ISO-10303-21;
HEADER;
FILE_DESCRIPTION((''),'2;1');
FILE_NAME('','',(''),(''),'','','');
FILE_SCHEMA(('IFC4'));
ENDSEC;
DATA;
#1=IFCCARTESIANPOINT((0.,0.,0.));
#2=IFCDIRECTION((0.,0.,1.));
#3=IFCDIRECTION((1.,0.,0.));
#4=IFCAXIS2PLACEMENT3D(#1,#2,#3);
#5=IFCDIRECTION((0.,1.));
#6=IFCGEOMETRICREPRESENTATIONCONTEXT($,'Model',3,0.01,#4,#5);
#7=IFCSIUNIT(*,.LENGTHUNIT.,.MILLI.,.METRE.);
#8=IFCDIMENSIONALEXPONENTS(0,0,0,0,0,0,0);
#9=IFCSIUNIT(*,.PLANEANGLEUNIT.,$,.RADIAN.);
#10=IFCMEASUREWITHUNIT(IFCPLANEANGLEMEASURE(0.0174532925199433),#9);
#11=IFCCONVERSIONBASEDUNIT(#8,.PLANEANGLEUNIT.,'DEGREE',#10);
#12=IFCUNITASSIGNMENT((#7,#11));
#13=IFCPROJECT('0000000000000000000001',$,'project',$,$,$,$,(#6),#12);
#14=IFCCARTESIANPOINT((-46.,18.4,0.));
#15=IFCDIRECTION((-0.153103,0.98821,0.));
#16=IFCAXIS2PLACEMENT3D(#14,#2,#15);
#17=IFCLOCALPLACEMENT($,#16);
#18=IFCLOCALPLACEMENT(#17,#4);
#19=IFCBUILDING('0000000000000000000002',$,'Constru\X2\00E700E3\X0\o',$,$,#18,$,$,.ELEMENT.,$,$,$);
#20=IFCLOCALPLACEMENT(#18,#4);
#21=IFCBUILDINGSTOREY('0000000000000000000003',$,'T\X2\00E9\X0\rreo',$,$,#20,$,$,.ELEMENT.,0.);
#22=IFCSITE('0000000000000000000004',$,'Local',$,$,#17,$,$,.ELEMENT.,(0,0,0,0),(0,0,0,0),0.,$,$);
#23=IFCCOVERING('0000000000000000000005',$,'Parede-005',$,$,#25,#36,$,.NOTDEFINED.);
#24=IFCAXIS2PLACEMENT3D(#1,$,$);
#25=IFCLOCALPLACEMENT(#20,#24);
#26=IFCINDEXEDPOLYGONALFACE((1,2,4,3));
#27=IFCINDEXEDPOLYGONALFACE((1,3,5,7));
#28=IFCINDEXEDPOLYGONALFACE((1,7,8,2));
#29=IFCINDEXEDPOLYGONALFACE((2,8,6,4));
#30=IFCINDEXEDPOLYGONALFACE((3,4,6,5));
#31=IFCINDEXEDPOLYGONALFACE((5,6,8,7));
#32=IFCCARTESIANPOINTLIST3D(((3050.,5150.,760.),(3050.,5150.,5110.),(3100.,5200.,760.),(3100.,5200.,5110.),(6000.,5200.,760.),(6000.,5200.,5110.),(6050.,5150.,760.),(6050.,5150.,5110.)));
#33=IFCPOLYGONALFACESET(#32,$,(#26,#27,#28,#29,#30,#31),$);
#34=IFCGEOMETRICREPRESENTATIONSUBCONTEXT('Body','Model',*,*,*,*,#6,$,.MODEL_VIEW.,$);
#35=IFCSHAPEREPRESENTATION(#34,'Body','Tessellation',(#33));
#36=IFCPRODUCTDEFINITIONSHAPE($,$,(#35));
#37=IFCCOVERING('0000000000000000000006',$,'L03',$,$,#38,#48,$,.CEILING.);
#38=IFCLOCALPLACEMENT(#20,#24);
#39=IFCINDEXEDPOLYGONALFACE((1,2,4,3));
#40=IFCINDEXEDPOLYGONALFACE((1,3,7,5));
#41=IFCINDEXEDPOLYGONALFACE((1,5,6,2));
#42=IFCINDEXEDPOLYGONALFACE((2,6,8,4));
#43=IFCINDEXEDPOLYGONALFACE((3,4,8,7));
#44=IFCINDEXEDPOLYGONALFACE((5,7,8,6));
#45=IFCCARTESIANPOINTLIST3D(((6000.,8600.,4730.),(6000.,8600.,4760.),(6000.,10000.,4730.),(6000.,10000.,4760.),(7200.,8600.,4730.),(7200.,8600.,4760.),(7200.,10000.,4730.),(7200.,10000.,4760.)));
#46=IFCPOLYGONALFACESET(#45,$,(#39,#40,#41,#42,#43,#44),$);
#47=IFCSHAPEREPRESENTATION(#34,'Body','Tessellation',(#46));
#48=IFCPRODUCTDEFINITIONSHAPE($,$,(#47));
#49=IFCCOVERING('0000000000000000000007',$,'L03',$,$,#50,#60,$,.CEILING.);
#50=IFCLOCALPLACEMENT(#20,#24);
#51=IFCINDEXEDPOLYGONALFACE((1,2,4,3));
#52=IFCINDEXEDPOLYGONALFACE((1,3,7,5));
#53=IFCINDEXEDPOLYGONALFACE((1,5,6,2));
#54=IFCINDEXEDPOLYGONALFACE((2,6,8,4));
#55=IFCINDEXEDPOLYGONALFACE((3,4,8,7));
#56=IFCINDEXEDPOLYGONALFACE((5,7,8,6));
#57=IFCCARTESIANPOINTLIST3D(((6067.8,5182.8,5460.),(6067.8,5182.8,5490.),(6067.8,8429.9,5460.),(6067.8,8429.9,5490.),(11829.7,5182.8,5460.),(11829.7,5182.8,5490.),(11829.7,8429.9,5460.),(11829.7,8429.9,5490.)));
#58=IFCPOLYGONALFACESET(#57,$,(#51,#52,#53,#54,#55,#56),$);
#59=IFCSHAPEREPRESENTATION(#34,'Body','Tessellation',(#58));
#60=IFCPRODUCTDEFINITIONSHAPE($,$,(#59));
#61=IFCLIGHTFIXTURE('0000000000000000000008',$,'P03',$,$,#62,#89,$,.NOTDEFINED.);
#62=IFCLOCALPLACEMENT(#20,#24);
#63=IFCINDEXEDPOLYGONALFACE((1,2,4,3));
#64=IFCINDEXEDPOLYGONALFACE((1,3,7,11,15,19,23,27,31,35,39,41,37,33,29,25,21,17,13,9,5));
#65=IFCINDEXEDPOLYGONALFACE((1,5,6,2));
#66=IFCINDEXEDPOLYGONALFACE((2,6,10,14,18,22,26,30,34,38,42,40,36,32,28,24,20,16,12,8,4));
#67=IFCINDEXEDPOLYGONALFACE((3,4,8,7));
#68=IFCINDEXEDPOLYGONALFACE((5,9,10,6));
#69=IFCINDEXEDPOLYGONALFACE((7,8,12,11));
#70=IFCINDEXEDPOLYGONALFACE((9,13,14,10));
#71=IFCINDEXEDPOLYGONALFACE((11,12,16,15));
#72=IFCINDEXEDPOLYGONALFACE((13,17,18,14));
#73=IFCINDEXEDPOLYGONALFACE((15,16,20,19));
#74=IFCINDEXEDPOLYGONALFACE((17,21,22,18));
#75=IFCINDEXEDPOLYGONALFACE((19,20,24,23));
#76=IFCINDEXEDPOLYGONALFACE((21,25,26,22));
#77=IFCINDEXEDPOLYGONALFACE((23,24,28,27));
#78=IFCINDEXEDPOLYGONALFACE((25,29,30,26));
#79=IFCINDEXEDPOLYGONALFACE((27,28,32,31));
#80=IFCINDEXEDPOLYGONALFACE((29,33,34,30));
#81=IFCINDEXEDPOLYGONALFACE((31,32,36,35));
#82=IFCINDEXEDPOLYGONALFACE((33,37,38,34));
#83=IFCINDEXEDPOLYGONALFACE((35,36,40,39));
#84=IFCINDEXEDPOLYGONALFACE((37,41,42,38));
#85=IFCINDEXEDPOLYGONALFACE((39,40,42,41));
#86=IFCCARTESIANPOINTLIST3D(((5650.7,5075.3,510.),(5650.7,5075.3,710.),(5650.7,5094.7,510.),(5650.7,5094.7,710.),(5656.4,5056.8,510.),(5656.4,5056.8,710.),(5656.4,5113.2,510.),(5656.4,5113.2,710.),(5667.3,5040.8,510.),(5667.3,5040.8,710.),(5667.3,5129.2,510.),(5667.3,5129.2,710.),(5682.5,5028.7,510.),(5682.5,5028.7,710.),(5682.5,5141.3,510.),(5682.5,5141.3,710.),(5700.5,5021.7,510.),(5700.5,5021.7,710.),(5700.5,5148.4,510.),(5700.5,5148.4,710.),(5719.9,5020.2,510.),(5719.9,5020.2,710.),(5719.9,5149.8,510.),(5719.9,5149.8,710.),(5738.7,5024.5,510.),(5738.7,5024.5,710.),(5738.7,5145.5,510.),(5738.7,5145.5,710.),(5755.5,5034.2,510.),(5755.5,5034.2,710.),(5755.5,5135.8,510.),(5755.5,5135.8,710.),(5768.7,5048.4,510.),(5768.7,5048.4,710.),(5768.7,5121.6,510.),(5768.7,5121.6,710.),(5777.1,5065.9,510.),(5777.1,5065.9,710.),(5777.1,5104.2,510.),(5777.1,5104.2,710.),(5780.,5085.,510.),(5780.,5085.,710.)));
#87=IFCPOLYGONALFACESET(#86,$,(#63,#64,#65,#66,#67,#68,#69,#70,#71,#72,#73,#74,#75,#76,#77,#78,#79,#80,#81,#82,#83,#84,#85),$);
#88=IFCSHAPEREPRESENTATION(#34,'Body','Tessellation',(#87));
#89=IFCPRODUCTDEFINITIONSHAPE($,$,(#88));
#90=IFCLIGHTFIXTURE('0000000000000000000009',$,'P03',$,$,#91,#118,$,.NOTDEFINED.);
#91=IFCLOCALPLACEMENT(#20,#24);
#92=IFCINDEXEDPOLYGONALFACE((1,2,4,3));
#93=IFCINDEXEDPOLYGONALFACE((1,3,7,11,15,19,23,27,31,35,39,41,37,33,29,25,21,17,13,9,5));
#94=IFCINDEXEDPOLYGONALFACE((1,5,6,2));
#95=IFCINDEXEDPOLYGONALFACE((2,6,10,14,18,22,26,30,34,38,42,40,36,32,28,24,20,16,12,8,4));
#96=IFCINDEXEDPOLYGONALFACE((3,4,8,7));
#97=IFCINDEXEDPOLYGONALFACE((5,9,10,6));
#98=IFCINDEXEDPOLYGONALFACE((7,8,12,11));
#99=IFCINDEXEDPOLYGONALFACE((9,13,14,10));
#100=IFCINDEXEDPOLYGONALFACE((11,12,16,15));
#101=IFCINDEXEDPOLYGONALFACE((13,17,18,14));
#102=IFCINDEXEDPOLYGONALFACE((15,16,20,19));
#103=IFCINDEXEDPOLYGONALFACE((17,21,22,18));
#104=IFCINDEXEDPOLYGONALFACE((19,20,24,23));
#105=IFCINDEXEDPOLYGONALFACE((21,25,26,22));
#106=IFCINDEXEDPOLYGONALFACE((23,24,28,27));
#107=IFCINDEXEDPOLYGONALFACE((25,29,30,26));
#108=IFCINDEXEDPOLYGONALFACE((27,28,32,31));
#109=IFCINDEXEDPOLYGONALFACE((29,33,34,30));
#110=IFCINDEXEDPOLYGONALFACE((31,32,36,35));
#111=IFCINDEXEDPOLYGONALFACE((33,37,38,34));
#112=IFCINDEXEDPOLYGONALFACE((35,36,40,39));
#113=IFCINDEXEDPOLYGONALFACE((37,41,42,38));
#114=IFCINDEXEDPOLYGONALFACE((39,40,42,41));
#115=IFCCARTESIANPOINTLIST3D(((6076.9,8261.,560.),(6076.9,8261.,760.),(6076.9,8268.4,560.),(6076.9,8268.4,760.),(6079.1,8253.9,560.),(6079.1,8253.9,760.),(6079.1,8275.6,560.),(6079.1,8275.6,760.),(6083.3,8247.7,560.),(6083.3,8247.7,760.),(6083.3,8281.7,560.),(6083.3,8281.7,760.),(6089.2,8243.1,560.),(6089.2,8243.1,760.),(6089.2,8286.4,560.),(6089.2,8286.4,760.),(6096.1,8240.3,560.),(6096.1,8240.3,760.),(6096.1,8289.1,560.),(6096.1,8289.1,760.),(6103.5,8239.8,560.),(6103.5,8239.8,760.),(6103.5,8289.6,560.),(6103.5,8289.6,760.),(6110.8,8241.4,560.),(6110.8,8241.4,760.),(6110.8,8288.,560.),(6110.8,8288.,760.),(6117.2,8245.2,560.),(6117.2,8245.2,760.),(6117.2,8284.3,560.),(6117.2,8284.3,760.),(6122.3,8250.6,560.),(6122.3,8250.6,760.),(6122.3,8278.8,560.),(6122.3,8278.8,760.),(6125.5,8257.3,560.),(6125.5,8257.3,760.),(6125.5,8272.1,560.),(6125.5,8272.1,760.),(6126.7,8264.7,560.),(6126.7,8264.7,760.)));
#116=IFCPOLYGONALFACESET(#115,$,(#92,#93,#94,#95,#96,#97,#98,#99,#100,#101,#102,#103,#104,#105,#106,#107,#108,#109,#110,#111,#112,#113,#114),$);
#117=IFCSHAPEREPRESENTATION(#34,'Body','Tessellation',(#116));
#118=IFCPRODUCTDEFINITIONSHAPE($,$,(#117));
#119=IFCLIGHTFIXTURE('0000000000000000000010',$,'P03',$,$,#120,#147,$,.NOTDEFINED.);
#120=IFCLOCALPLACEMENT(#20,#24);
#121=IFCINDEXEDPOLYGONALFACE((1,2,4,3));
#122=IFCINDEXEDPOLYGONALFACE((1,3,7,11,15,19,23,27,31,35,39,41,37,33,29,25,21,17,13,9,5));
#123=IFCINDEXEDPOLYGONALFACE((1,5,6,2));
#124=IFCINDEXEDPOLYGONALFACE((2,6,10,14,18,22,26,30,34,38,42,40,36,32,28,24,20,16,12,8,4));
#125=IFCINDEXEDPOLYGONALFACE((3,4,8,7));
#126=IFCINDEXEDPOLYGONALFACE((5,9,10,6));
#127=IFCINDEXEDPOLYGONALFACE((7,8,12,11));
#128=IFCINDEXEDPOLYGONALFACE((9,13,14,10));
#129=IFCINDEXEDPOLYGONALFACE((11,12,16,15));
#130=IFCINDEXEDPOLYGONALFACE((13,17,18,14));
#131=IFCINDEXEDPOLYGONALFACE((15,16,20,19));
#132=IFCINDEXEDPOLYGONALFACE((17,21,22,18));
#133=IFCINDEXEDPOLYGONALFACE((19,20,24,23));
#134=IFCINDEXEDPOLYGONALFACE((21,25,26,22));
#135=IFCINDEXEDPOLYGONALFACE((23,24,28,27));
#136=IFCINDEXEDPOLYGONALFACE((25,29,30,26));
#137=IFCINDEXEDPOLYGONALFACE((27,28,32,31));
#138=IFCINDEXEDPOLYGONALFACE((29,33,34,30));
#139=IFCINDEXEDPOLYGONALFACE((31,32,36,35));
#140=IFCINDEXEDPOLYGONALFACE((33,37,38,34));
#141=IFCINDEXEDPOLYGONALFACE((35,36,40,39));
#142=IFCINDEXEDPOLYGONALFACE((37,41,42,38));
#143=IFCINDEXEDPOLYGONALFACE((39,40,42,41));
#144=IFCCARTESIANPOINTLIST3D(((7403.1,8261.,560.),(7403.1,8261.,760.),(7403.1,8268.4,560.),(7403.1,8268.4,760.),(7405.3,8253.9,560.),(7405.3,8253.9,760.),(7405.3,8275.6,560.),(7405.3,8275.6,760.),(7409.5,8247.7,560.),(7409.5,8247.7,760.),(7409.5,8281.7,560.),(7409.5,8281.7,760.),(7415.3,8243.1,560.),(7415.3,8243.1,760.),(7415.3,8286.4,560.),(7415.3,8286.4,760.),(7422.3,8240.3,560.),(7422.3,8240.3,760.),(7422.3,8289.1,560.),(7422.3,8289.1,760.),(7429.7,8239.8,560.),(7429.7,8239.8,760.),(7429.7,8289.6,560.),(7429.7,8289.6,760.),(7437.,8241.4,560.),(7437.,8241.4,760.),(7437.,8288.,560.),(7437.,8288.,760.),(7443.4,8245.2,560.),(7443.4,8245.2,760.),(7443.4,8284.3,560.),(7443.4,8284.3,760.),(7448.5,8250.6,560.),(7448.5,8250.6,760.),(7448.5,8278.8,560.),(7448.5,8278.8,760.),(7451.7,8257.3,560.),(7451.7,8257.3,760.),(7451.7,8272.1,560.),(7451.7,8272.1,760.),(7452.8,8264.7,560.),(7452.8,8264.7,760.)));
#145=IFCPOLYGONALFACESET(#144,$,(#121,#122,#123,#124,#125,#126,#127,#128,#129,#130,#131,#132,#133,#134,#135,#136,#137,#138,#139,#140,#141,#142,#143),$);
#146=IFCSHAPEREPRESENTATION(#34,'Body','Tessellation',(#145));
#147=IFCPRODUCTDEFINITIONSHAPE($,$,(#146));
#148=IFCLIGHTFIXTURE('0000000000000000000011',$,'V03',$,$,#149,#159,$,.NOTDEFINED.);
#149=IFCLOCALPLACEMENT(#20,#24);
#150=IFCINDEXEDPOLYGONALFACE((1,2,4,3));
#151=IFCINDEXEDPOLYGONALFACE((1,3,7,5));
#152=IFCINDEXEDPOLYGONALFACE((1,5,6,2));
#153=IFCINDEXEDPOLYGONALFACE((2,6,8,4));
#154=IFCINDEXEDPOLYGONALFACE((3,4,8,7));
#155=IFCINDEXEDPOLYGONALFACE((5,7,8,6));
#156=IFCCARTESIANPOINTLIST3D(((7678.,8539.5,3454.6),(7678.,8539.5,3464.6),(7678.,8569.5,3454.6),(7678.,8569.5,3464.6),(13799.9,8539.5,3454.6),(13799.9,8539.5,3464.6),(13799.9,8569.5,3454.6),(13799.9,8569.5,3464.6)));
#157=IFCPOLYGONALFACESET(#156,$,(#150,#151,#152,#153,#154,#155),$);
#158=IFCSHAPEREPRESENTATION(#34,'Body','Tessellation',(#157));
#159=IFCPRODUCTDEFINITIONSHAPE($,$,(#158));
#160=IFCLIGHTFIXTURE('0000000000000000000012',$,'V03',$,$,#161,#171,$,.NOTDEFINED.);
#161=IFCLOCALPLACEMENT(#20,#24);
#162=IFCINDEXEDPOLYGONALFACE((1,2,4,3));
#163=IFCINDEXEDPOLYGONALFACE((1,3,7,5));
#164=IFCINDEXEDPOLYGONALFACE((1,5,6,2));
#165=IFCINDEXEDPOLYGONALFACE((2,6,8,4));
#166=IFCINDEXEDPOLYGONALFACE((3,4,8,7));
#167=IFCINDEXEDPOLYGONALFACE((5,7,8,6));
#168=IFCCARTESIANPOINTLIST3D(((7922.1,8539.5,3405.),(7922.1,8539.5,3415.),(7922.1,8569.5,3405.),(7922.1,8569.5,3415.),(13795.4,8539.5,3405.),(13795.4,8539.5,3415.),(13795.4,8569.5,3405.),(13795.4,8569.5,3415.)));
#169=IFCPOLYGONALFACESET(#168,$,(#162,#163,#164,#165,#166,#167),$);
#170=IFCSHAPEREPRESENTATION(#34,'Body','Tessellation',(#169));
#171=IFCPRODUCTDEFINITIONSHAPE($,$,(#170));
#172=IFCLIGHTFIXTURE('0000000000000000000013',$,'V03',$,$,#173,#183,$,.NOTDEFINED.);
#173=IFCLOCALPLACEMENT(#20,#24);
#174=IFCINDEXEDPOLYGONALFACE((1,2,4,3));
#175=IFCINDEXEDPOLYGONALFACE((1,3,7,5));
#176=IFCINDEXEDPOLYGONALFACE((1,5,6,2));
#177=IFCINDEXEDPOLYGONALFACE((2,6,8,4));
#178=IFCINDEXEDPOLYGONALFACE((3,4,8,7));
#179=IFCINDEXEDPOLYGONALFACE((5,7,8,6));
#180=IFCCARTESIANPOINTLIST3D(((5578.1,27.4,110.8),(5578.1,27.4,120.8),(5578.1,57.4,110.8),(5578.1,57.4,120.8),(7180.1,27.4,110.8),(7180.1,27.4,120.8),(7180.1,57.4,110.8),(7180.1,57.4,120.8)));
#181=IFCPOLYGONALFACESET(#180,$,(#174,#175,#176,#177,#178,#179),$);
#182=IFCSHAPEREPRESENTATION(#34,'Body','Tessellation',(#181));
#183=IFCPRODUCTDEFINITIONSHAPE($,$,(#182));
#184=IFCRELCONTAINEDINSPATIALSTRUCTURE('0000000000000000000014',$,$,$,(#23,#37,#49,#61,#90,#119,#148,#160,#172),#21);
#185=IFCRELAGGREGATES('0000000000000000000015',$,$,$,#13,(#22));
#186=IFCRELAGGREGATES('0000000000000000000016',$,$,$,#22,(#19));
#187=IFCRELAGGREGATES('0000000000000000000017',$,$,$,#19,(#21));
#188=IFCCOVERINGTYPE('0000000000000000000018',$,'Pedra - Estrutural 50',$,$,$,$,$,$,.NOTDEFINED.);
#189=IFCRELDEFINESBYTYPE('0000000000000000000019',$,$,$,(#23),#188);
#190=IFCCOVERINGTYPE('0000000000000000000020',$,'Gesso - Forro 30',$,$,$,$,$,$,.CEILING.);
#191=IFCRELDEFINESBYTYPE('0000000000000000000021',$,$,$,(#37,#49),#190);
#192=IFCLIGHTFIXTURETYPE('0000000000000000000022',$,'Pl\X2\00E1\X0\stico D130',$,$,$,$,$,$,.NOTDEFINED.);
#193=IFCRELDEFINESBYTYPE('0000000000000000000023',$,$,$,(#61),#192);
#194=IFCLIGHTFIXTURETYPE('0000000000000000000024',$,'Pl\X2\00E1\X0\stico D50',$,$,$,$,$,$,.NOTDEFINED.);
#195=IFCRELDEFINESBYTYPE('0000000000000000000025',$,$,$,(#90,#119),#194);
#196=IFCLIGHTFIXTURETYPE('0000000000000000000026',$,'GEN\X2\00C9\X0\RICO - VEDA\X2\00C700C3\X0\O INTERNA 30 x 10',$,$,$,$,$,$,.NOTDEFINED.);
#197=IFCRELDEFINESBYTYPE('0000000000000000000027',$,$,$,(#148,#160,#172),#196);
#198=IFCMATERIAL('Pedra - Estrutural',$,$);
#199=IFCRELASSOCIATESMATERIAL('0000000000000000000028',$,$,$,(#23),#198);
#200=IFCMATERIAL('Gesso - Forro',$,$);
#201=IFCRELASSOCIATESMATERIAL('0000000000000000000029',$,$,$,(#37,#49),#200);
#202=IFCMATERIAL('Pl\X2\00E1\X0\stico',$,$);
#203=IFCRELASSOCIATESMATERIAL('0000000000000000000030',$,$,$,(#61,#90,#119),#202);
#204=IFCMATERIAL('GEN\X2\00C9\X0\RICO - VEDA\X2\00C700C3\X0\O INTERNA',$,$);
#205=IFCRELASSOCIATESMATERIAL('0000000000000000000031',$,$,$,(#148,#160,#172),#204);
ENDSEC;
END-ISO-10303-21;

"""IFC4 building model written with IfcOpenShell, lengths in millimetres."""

from ifc_helpers import new_model, entity, si_unit, converted_unit, direction, frame, frame_2d, origin_with_axes, origin_2d_with_axis, place, context, subcontext, project, spatial, line, indexed_curve, rectangle, circle, outline, extrude, material, type_object, element, save


model = new_model("IFC4")

# Units and contexts
model_context = context("Model", 3, precision=0.01, world=origin_with_axes(), true_north=direction((0.0, 1.0)))
body_context = subcontext(model_context, "Body", "Model", "MODEL_VIEW")
ifc_project = project(units=[si_unit("LENGTHUNIT", "METRE", prefix="MILLI"), converted_unit("PLANEANGLEUNIT", "DEGREE", entity("IfcPlaneAngleMeasure", 0.0174532925199433), si_unit("PLANEANGLEUNIT", "RADIAN"), dimensions=[0, 0, 0, 0, 0, 0, 0])], contexts=[model_context])

# Site, building, storey
site_placement = place(None, frame((-46.0, 18.4, 0.0), z_axis=(0.0, 0.0, 1.0), x_axis=(-0.153103, 0.98821, 0.0)))
site = spatial("IfcSite", under=ifc_project, at=site_placement, Name="Local", CompositionType="ELEMENT", RefLatitude=(0, 0, 0, 0), RefLongitude=(0, 0, 0, 0), RefElevation=0.0)
building_placement = place(site_placement, origin_with_axes())
building = spatial("IfcBuilding", under=site, at=building_placement, Name="Construção", CompositionType="ELEMENT")
storey_placement = place(building_placement, origin_with_axes())
storey = spatial("IfcBuildingStorey", under=building, at=storey_placement, Name="Térreo", CompositionType="ELEMENT", Elevation=0.0)

# Shared definitions
ifc_material_1 = material(Name="Pedra - Estrutural")

# Coverings
covering_type_1 = type_object("IfcCoveringType", Name="Pedra - Estrutural 50", PredefinedType="NOTDEFINED")
covering_1_placement = place(storey_placement, frame((6000.0, 5200.0, 760.0), z_axis=(0.0, 0.0, 1.0), x_axis=(-1.0, -0.000002, 0.0)))
element("IfcCovering", 1, at=covering_1_placement, inside=storey, type_object=covering_type_1, material=ifc_material_1, Name="Parede-005", PredefinedType="NOTDEFINED", context=body_context, shape_type="SweptSolid", body=[
    extrude(outline(indexed_curve([(0.0, 0.0), (2900.0, 0.0), (2950.0, 50.0), (-50.0, 50.0)], segments=[line(1, 2, 3, 4, 1)])), origin_with_axes(), (0.0, 0.0, 1.0), 4350.0),
])
ifc_material_2 = material(Name="Gesso - Forro")
covering_type_2 = type_object("IfcCoveringType", Name="Gesso - Forro 30", PredefinedType="CEILING")
covering_2_placement = place(storey_placement, frame((6000.0, 8600.0, 4760.0), z_axis=(0.0, 0.0, 1.0), x_axis=(1.0, 0.0, 0.0)))
element("IfcCovering", 2, at=covering_2_placement, inside=storey, type_object=covering_type_2, material=ifc_material_2, Name="L03", PredefinedType="CEILING", context=body_context, shape_type="SweptSolid", body=[
    extrude(outline(indexed_curve([(0.0, 0.0), (1200.0, 0.0), (1200.0, 1400.0), (0.0, 1400.0)], segments=[line(1, 2, 3, 4, 1)])), frame((0.0, 0.0, -30.0), z_axis=(0.0, 0.0, 1.0), x_axis=(1.0, 0.0, 0.0)), (0.0, 0.0, 1.0), 30.0),
])
covering_3_placement = place(storey_placement, frame((6067.8, 8429.9, 5490.0), z_axis=(0.0, 0.0, 1.0), x_axis=(1.0, 0.0, 0.0)))
element("IfcCovering", 3, at=covering_3_placement, inside=storey, type_object=covering_type_2, material=ifc_material_2, Name="L03", PredefinedType="CEILING", context=body_context, shape_type="SweptSolid", body=[
    extrude(outline(indexed_curve([(0.0, 0.0), (0.0, -3247.1), (5761.9, -3247.1), (5761.9, 0.0)], segments=[line(1, 2, 3, 4, 1)])), frame((0.0, 0.0, -30.0), z_axis=(0.0, 0.0, 1.0), x_axis=(1.0, 0.0, 0.0)), (0.0, 0.0, 1.0), 30.0),
])

# Light fixtures
ifc_material_3 = material(Name="Plástico")
light_fixture_type_1 = type_object("IfcLightFixtureType", Name="Plástico D130", PredefinedType="NOTDEFINED")
light_fixture_1_placement = place(storey_placement, frame((5715.0, 5085.0, 510.0), z_axis=(0.0, 0.0, 1.0), x_axis=(1.0, 0.0, 0.0)))
element("IfcLightFixture", 4, at=light_fixture_1_placement, inside=storey, type_object=light_fixture_type_1, material=ifc_material_3, Name="P03", PredefinedType="NOTDEFINED", context=body_context, shape_type="SweptSolid", body=[
    extrude(circle(Radius=65.0, at=origin_2d_with_axis()), origin_with_axes(), (0.0, 0.0, 1.0), 200.0),
])
light_fixture_type_2 = type_object("IfcLightFixtureType", Name="Plástico D50", PredefinedType="NOTDEFINED")
light_fixture_2_placement = place(storey_placement, frame((6101.7, 8264.7, 560.0), z_axis=(0.0, 0.0, 1.0), x_axis=(1.0, 0.0, 0.0)))
element("IfcLightFixture", 5, at=light_fixture_2_placement, inside=storey, type_object=light_fixture_type_2, material=ifc_material_3, Name="P03", PredefinedType="NOTDEFINED", context=body_context, shape_type="SweptSolid", body=[
    extrude(circle(Radius=25.0, at=origin_2d_with_axis()), origin_with_axes(), (0.0, 0.0, 1.0), 200.0),
])
light_fixture_3_placement = place(storey_placement, frame((7427.8, 8264.7, 560.0), z_axis=(0.0, 0.0, 1.0), x_axis=(1.0, 0.0, 0.0)))
element("IfcLightFixture", 6, at=light_fixture_3_placement, inside=storey, type_object=light_fixture_type_2, material=ifc_material_3, Name="P03", PredefinedType="NOTDEFINED", context=body_context, shape_type="SweptSolid", body=[
    extrude(circle(Radius=25.0, at=origin_2d_with_axis()), origin_with_axes(), (0.0, 0.0, 1.0), 200.0),
])
ifc_material_4 = material(Name="GENÉRICO - VEDAÇÃO INTERNA")
light_fixture_type_3 = type_object("IfcLightFixtureType", Name="GENÉRICO - VEDAÇÃO INTERNA 30 x 10", PredefinedType="NOTDEFINED")
light_fixture_4_placement = place(storey_placement, frame((7678.0, 8569.5, 3464.6), z_axis=(0.0, 0.0, 1.0), x_axis=(0.000002, -1.0, 0.0)))
element("IfcLightFixture", 7, at=light_fixture_4_placement, inside=storey, type_object=light_fixture_type_3, material=ifc_material_4, Name="V03", PredefinedType="NOTDEFINED", context=body_context, shape_type="SweptSolid", body=[
    extrude(rectangle(XDim=10.0, YDim=30.0, at=frame_2d((-5.0, 15.0), x_axis=(1.0, 0.0))), frame((0.0, 0.0, 0.0), z_axis=(0.0, 1.0, 0.0), x_axis=(0.0, 0.0, 1.0)), (0.0, 0.0, 1.0), 6122.0),
])
light_fixture_5_placement = place(storey_placement, frame((7922.1, 8569.5, 3415.0), z_axis=(0.0, 0.0, 1.0), x_axis=(0.0, -1.0, 0.0)))
element("IfcLightFixture", 8, at=light_fixture_5_placement, inside=storey, type_object=light_fixture_type_3, material=ifc_material_4, Name="V03", PredefinedType="NOTDEFINED", context=body_context, shape_type="SweptSolid", body=[
    extrude(rectangle(XDim=10.0, YDim=30.0, at=frame_2d((-5.0, 15.0), x_axis=(1.0, 0.0))), frame((0.0, 0.0, 0.0), z_axis=(0.0, 1.0, 0.0), x_axis=(0.0, 0.0, 1.0)), (0.0, 0.0, 1.0), 5873.4),
])
light_fixture_6_placement = place(storey_placement, frame((5578.1, 57.4, 120.8), z_axis=(0.0, 0.0, 1.0), x_axis=(0.0, -1.0, 0.0)))
element("IfcLightFixture", 9, at=light_fixture_6_placement, inside=storey, type_object=light_fixture_type_3, material=ifc_material_4, Name="V03", PredefinedType="NOTDEFINED", context=body_context, shape_type="SweptSolid", body=[
    extrude(rectangle(XDim=10.0, YDim=30.0, at=frame_2d((-5.0, 15.0), x_axis=(1.0, 0.0))), frame((0.0, 0.0, 0.0), z_axis=(0.0, 1.0, 0.0), x_axis=(0.0, 0.0, 1.0)), (0.0, 0.0, 1.0), 1602.1),
])

save(model, "model.ifc")
